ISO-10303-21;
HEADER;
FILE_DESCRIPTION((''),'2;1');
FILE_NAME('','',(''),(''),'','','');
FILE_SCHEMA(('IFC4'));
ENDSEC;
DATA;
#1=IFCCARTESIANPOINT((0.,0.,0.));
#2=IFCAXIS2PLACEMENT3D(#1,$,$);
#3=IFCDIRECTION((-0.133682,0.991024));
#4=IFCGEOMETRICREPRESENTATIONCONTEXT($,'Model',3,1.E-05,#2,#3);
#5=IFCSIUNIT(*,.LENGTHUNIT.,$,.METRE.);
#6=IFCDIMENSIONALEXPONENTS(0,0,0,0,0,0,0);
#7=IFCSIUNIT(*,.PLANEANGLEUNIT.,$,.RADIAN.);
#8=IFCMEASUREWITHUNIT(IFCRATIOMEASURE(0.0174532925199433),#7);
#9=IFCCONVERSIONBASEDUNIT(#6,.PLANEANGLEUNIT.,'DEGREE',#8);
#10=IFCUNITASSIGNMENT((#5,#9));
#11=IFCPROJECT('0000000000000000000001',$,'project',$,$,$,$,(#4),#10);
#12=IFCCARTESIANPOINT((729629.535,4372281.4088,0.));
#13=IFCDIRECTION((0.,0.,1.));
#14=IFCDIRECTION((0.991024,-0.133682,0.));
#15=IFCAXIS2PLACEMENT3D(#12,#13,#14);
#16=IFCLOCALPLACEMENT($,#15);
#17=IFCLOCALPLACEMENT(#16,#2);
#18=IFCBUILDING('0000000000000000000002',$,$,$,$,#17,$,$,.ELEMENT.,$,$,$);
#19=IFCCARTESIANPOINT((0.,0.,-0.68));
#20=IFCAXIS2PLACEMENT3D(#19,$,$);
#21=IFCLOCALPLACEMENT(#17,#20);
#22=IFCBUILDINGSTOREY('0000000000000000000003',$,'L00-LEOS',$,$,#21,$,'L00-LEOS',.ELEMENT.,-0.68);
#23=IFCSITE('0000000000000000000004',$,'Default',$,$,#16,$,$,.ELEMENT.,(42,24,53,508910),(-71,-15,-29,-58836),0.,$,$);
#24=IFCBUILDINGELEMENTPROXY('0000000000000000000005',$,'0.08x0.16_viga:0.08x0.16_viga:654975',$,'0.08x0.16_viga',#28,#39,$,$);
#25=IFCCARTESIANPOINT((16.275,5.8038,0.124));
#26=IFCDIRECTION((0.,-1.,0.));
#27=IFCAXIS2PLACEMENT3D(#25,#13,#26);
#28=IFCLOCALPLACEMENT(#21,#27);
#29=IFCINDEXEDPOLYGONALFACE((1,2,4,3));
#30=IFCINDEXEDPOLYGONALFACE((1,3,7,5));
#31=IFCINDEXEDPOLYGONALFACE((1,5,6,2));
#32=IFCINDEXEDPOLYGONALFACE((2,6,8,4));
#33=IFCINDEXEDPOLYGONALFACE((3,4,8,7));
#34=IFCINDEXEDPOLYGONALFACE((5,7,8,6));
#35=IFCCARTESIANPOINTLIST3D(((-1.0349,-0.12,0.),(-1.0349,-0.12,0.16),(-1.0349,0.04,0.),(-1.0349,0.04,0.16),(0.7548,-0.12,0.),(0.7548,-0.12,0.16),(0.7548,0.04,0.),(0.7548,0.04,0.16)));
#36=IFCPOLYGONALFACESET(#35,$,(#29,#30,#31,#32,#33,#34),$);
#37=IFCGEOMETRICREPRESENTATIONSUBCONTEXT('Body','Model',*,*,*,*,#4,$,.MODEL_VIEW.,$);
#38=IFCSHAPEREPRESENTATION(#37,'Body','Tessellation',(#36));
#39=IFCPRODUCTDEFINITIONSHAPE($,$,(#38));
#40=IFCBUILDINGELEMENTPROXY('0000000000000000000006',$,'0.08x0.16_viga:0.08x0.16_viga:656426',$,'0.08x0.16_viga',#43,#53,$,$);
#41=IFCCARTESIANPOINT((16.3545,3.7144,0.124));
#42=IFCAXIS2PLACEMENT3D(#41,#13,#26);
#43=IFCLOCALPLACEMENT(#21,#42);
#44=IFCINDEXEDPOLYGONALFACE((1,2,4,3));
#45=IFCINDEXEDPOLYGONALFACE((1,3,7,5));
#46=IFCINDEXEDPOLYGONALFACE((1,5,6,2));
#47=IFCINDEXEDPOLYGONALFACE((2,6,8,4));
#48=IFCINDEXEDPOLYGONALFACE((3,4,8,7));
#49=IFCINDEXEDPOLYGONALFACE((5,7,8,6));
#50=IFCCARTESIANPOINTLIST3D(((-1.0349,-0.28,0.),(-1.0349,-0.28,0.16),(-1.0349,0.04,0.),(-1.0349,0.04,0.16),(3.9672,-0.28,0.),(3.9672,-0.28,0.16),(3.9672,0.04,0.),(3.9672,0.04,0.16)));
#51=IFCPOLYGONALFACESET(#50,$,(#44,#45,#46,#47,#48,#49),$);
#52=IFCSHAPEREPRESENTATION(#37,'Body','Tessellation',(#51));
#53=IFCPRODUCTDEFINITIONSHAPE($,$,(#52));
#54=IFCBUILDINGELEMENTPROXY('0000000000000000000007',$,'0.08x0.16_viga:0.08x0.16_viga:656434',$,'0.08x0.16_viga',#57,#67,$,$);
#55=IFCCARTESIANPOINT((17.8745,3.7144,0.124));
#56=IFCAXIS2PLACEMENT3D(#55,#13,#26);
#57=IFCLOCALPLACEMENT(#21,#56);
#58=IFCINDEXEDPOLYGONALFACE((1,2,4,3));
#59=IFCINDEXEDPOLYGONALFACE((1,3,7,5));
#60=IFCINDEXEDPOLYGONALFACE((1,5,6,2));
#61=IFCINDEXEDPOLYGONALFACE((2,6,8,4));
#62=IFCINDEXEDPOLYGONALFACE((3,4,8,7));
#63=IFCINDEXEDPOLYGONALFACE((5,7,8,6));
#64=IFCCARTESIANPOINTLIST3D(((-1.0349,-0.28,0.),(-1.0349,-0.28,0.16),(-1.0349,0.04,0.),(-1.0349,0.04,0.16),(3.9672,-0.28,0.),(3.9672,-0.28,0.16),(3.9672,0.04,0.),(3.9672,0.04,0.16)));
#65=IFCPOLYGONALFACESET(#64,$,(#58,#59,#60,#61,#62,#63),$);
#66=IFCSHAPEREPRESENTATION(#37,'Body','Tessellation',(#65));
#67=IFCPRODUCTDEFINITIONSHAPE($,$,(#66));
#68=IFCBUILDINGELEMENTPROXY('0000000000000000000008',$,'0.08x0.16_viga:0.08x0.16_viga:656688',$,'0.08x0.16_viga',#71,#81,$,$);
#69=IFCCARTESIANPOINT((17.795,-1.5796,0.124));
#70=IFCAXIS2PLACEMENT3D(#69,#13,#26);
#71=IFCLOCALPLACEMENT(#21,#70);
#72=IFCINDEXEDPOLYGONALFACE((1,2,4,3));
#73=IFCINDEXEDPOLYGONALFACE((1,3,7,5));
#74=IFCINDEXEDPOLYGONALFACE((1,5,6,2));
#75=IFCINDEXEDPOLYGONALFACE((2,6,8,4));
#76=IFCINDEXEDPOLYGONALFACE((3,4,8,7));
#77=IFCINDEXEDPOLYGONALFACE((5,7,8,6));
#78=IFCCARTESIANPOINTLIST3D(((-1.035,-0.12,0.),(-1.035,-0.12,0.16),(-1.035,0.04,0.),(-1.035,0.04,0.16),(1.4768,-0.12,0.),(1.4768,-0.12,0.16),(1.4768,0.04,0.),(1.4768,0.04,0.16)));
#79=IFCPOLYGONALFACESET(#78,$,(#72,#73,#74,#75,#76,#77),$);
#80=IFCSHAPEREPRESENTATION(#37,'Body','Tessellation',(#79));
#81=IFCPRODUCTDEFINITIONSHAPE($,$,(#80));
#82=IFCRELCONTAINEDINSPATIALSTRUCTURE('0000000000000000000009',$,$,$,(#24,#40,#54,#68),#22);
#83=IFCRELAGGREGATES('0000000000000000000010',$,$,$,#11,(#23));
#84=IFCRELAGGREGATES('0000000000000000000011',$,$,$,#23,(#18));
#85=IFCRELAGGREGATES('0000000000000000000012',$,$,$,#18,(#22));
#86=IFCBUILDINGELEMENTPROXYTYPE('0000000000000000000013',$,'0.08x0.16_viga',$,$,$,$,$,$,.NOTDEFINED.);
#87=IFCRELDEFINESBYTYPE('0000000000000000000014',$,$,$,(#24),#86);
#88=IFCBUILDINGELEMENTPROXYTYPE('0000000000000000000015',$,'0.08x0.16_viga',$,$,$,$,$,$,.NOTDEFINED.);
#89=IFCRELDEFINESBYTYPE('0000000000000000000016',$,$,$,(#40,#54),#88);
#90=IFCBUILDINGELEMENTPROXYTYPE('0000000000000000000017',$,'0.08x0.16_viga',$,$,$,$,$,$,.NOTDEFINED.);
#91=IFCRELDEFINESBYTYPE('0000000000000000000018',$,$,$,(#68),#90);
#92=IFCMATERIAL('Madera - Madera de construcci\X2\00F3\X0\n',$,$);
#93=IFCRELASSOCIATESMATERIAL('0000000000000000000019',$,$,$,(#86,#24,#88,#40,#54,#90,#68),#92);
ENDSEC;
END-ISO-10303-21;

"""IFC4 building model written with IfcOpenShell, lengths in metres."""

from ifc_helpers import new_model, entity, si_unit, converted_unit, direction, frame, origin, origin_2d_with_axis, place, context, subcontext, project, spatial, rectangle, extrude, source, transform, mapped, material, type_object, type_shapes, element, save


model = new_model("IFC4")

# Units and contexts
model_context = context("Model", 3, precision=1e-05, world=origin(), true_north=direction((-0.133682, 0.991024)))
body_context = subcontext(model_context, "Body", "Model", "MODEL_VIEW")
ifc_project = project(units=[si_unit("LENGTHUNIT", "METRE"), converted_unit("PLANEANGLEUNIT", "DEGREE", entity("IfcRatioMeasure", 0.0174532925199433), si_unit("PLANEANGLEUNIT", "RADIAN"), dimensions=[0, 0, 0, 0, 0, 0, 0])], contexts=[model_context])

# Site, building, storey
site_placement = place(None, frame((729629.535, 4372281.4088, 0.0), z_axis=(0.0, 0.0, 1.0), x_axis=(0.991024, -0.133682, 0.0)))
site = spatial("IfcSite", under=ifc_project, at=site_placement, Name="Default", CompositionType="ELEMENT", RefLatitude=(42, 24, 53, 508910), RefLongitude=(-71, -15, -29, -58836), RefElevation=0.0)
building_placement = place(site_placement, origin())
building = spatial("IfcBuilding", under=site, at=building_placement, CompositionType="ELEMENT")
storey_placement = place(building_placement, frame((0.0, 0.0, -0.68)))
storey = spatial("IfcBuildingStorey", under=building, at=storey_placement, Name="L00-LEOS", LongName="L00-LEOS", CompositionType="ELEMENT", Elevation=-0.68)

# Building element proxies
ifc_material = material(Name="Madera - Madera de construcción")
building_element_proxy_type_1 = type_object("IfcBuildingElementProxyType", Name="0.08x0.16_viga", material=ifc_material)
shared_shape_1 = source(origin(), body_context, "Body", "SweptSolid", [
    extrude(rectangle(XDim=0.16, YDim=1.7897, at=origin_2d_with_axis()), frame((-0.1401, -0.04, 0.0), z_axis=(0.0, 0.0, 1.0), x_axis=(0.0, -1.0, 0.0)), (0.0, 0.0, 1.0), 0.16),
])
type_shapes(building_element_proxy_type_1, [shared_shape_1])
proxy_1_placement = place(storey_placement, frame((16.275, 5.8038, 0.124), z_axis=(0.0, 0.0, 1.0), x_axis=(0.0, -1.0, 0.0)))
element("IfcBuildingElementProxy", 1, at=proxy_1_placement, inside=storey, type_object=building_element_proxy_type_1, material=ifc_material, Name="0.08x0.16_viga:0.08x0.16_viga:654975", ObjectType="0.08x0.16_viga", context=body_context, shape_type="MappedRepresentation", body=[
    mapped(shared_shape_1, transform((0.0, 0.0, 0.0), scale=1.0)),
])
building_element_proxy_type_2 = type_object("IfcBuildingElementProxyType", Name="0.08x0.16_viga", material=ifc_material)
shared_shape_2 = source(origin(), body_context, "Body", "SweptSolid", [
    extrude(rectangle(XDim=0.32, YDim=5.0021, at=origin_2d_with_axis()), frame((1.4661, -0.12, 0.0), z_axis=(0.0, 0.0, 1.0), x_axis=(0.0, -1.0, 0.0)), (0.0, 0.0, 1.0), 0.16),
])
type_shapes(building_element_proxy_type_2, [shared_shape_2])
for number, where, z_axis, x_axis, name in (
    (2, (16.3545, 3.7144, 0.124), (0.0, 0.0, 1.0), (0.0, -1.0, 0.0), "0.08x0.16_viga:0.08x0.16_viga:656426"),
    (3, (17.8745, 3.7144, 0.124), (0.0, 0.0, 1.0), (0.0, -1.0, 0.0), "0.08x0.16_viga:0.08x0.16_viga:656434"),
):
    element("IfcBuildingElementProxy", number, at=place(storey_placement, frame(where, z_axis=z_axis, x_axis=x_axis)), inside=storey, type_object=building_element_proxy_type_2, material=ifc_material, Name=name, ObjectType="0.08x0.16_viga", context=body_context, shape_type="MappedRepresentation", body=[
        mapped(shared_shape_2, transform((0.0, 0.0, 0.0), scale=1.0)),
    ])
building_element_proxy_type_3 = type_object("IfcBuildingElementProxyType", Name="0.08x0.16_viga", material=ifc_material)
shared_shape_3 = source(origin(), body_context, "Body", "SweptSolid", [
    extrude(rectangle(XDim=0.16, YDim=2.5117, at=origin_2d_with_axis()), frame((0.2209, -0.04, 0.0), z_axis=(0.0, 0.0, 1.0), x_axis=(0.0, -1.0, 0.0)), (0.0, 0.0, 1.0), 0.16),
])
type_shapes(building_element_proxy_type_3, [shared_shape_3])
proxy_2_placement = place(storey_placement, frame((17.795, -1.5796, 0.124), z_axis=(0.0, 0.0, 1.0), x_axis=(0.0, -1.0, 0.0)))
element("IfcBuildingElementProxy", 4, at=proxy_2_placement, inside=storey, type_object=building_element_proxy_type_3, material=ifc_material, Name="0.08x0.16_viga:0.08x0.16_viga:656688", ObjectType="0.08x0.16_viga", context=body_context, shape_type="MappedRepresentation", body=[
    mapped(shared_shape_3, transform((0.0, 0.0, 0.0), scale=1.0)),
])

save(model, "model.ifc")
